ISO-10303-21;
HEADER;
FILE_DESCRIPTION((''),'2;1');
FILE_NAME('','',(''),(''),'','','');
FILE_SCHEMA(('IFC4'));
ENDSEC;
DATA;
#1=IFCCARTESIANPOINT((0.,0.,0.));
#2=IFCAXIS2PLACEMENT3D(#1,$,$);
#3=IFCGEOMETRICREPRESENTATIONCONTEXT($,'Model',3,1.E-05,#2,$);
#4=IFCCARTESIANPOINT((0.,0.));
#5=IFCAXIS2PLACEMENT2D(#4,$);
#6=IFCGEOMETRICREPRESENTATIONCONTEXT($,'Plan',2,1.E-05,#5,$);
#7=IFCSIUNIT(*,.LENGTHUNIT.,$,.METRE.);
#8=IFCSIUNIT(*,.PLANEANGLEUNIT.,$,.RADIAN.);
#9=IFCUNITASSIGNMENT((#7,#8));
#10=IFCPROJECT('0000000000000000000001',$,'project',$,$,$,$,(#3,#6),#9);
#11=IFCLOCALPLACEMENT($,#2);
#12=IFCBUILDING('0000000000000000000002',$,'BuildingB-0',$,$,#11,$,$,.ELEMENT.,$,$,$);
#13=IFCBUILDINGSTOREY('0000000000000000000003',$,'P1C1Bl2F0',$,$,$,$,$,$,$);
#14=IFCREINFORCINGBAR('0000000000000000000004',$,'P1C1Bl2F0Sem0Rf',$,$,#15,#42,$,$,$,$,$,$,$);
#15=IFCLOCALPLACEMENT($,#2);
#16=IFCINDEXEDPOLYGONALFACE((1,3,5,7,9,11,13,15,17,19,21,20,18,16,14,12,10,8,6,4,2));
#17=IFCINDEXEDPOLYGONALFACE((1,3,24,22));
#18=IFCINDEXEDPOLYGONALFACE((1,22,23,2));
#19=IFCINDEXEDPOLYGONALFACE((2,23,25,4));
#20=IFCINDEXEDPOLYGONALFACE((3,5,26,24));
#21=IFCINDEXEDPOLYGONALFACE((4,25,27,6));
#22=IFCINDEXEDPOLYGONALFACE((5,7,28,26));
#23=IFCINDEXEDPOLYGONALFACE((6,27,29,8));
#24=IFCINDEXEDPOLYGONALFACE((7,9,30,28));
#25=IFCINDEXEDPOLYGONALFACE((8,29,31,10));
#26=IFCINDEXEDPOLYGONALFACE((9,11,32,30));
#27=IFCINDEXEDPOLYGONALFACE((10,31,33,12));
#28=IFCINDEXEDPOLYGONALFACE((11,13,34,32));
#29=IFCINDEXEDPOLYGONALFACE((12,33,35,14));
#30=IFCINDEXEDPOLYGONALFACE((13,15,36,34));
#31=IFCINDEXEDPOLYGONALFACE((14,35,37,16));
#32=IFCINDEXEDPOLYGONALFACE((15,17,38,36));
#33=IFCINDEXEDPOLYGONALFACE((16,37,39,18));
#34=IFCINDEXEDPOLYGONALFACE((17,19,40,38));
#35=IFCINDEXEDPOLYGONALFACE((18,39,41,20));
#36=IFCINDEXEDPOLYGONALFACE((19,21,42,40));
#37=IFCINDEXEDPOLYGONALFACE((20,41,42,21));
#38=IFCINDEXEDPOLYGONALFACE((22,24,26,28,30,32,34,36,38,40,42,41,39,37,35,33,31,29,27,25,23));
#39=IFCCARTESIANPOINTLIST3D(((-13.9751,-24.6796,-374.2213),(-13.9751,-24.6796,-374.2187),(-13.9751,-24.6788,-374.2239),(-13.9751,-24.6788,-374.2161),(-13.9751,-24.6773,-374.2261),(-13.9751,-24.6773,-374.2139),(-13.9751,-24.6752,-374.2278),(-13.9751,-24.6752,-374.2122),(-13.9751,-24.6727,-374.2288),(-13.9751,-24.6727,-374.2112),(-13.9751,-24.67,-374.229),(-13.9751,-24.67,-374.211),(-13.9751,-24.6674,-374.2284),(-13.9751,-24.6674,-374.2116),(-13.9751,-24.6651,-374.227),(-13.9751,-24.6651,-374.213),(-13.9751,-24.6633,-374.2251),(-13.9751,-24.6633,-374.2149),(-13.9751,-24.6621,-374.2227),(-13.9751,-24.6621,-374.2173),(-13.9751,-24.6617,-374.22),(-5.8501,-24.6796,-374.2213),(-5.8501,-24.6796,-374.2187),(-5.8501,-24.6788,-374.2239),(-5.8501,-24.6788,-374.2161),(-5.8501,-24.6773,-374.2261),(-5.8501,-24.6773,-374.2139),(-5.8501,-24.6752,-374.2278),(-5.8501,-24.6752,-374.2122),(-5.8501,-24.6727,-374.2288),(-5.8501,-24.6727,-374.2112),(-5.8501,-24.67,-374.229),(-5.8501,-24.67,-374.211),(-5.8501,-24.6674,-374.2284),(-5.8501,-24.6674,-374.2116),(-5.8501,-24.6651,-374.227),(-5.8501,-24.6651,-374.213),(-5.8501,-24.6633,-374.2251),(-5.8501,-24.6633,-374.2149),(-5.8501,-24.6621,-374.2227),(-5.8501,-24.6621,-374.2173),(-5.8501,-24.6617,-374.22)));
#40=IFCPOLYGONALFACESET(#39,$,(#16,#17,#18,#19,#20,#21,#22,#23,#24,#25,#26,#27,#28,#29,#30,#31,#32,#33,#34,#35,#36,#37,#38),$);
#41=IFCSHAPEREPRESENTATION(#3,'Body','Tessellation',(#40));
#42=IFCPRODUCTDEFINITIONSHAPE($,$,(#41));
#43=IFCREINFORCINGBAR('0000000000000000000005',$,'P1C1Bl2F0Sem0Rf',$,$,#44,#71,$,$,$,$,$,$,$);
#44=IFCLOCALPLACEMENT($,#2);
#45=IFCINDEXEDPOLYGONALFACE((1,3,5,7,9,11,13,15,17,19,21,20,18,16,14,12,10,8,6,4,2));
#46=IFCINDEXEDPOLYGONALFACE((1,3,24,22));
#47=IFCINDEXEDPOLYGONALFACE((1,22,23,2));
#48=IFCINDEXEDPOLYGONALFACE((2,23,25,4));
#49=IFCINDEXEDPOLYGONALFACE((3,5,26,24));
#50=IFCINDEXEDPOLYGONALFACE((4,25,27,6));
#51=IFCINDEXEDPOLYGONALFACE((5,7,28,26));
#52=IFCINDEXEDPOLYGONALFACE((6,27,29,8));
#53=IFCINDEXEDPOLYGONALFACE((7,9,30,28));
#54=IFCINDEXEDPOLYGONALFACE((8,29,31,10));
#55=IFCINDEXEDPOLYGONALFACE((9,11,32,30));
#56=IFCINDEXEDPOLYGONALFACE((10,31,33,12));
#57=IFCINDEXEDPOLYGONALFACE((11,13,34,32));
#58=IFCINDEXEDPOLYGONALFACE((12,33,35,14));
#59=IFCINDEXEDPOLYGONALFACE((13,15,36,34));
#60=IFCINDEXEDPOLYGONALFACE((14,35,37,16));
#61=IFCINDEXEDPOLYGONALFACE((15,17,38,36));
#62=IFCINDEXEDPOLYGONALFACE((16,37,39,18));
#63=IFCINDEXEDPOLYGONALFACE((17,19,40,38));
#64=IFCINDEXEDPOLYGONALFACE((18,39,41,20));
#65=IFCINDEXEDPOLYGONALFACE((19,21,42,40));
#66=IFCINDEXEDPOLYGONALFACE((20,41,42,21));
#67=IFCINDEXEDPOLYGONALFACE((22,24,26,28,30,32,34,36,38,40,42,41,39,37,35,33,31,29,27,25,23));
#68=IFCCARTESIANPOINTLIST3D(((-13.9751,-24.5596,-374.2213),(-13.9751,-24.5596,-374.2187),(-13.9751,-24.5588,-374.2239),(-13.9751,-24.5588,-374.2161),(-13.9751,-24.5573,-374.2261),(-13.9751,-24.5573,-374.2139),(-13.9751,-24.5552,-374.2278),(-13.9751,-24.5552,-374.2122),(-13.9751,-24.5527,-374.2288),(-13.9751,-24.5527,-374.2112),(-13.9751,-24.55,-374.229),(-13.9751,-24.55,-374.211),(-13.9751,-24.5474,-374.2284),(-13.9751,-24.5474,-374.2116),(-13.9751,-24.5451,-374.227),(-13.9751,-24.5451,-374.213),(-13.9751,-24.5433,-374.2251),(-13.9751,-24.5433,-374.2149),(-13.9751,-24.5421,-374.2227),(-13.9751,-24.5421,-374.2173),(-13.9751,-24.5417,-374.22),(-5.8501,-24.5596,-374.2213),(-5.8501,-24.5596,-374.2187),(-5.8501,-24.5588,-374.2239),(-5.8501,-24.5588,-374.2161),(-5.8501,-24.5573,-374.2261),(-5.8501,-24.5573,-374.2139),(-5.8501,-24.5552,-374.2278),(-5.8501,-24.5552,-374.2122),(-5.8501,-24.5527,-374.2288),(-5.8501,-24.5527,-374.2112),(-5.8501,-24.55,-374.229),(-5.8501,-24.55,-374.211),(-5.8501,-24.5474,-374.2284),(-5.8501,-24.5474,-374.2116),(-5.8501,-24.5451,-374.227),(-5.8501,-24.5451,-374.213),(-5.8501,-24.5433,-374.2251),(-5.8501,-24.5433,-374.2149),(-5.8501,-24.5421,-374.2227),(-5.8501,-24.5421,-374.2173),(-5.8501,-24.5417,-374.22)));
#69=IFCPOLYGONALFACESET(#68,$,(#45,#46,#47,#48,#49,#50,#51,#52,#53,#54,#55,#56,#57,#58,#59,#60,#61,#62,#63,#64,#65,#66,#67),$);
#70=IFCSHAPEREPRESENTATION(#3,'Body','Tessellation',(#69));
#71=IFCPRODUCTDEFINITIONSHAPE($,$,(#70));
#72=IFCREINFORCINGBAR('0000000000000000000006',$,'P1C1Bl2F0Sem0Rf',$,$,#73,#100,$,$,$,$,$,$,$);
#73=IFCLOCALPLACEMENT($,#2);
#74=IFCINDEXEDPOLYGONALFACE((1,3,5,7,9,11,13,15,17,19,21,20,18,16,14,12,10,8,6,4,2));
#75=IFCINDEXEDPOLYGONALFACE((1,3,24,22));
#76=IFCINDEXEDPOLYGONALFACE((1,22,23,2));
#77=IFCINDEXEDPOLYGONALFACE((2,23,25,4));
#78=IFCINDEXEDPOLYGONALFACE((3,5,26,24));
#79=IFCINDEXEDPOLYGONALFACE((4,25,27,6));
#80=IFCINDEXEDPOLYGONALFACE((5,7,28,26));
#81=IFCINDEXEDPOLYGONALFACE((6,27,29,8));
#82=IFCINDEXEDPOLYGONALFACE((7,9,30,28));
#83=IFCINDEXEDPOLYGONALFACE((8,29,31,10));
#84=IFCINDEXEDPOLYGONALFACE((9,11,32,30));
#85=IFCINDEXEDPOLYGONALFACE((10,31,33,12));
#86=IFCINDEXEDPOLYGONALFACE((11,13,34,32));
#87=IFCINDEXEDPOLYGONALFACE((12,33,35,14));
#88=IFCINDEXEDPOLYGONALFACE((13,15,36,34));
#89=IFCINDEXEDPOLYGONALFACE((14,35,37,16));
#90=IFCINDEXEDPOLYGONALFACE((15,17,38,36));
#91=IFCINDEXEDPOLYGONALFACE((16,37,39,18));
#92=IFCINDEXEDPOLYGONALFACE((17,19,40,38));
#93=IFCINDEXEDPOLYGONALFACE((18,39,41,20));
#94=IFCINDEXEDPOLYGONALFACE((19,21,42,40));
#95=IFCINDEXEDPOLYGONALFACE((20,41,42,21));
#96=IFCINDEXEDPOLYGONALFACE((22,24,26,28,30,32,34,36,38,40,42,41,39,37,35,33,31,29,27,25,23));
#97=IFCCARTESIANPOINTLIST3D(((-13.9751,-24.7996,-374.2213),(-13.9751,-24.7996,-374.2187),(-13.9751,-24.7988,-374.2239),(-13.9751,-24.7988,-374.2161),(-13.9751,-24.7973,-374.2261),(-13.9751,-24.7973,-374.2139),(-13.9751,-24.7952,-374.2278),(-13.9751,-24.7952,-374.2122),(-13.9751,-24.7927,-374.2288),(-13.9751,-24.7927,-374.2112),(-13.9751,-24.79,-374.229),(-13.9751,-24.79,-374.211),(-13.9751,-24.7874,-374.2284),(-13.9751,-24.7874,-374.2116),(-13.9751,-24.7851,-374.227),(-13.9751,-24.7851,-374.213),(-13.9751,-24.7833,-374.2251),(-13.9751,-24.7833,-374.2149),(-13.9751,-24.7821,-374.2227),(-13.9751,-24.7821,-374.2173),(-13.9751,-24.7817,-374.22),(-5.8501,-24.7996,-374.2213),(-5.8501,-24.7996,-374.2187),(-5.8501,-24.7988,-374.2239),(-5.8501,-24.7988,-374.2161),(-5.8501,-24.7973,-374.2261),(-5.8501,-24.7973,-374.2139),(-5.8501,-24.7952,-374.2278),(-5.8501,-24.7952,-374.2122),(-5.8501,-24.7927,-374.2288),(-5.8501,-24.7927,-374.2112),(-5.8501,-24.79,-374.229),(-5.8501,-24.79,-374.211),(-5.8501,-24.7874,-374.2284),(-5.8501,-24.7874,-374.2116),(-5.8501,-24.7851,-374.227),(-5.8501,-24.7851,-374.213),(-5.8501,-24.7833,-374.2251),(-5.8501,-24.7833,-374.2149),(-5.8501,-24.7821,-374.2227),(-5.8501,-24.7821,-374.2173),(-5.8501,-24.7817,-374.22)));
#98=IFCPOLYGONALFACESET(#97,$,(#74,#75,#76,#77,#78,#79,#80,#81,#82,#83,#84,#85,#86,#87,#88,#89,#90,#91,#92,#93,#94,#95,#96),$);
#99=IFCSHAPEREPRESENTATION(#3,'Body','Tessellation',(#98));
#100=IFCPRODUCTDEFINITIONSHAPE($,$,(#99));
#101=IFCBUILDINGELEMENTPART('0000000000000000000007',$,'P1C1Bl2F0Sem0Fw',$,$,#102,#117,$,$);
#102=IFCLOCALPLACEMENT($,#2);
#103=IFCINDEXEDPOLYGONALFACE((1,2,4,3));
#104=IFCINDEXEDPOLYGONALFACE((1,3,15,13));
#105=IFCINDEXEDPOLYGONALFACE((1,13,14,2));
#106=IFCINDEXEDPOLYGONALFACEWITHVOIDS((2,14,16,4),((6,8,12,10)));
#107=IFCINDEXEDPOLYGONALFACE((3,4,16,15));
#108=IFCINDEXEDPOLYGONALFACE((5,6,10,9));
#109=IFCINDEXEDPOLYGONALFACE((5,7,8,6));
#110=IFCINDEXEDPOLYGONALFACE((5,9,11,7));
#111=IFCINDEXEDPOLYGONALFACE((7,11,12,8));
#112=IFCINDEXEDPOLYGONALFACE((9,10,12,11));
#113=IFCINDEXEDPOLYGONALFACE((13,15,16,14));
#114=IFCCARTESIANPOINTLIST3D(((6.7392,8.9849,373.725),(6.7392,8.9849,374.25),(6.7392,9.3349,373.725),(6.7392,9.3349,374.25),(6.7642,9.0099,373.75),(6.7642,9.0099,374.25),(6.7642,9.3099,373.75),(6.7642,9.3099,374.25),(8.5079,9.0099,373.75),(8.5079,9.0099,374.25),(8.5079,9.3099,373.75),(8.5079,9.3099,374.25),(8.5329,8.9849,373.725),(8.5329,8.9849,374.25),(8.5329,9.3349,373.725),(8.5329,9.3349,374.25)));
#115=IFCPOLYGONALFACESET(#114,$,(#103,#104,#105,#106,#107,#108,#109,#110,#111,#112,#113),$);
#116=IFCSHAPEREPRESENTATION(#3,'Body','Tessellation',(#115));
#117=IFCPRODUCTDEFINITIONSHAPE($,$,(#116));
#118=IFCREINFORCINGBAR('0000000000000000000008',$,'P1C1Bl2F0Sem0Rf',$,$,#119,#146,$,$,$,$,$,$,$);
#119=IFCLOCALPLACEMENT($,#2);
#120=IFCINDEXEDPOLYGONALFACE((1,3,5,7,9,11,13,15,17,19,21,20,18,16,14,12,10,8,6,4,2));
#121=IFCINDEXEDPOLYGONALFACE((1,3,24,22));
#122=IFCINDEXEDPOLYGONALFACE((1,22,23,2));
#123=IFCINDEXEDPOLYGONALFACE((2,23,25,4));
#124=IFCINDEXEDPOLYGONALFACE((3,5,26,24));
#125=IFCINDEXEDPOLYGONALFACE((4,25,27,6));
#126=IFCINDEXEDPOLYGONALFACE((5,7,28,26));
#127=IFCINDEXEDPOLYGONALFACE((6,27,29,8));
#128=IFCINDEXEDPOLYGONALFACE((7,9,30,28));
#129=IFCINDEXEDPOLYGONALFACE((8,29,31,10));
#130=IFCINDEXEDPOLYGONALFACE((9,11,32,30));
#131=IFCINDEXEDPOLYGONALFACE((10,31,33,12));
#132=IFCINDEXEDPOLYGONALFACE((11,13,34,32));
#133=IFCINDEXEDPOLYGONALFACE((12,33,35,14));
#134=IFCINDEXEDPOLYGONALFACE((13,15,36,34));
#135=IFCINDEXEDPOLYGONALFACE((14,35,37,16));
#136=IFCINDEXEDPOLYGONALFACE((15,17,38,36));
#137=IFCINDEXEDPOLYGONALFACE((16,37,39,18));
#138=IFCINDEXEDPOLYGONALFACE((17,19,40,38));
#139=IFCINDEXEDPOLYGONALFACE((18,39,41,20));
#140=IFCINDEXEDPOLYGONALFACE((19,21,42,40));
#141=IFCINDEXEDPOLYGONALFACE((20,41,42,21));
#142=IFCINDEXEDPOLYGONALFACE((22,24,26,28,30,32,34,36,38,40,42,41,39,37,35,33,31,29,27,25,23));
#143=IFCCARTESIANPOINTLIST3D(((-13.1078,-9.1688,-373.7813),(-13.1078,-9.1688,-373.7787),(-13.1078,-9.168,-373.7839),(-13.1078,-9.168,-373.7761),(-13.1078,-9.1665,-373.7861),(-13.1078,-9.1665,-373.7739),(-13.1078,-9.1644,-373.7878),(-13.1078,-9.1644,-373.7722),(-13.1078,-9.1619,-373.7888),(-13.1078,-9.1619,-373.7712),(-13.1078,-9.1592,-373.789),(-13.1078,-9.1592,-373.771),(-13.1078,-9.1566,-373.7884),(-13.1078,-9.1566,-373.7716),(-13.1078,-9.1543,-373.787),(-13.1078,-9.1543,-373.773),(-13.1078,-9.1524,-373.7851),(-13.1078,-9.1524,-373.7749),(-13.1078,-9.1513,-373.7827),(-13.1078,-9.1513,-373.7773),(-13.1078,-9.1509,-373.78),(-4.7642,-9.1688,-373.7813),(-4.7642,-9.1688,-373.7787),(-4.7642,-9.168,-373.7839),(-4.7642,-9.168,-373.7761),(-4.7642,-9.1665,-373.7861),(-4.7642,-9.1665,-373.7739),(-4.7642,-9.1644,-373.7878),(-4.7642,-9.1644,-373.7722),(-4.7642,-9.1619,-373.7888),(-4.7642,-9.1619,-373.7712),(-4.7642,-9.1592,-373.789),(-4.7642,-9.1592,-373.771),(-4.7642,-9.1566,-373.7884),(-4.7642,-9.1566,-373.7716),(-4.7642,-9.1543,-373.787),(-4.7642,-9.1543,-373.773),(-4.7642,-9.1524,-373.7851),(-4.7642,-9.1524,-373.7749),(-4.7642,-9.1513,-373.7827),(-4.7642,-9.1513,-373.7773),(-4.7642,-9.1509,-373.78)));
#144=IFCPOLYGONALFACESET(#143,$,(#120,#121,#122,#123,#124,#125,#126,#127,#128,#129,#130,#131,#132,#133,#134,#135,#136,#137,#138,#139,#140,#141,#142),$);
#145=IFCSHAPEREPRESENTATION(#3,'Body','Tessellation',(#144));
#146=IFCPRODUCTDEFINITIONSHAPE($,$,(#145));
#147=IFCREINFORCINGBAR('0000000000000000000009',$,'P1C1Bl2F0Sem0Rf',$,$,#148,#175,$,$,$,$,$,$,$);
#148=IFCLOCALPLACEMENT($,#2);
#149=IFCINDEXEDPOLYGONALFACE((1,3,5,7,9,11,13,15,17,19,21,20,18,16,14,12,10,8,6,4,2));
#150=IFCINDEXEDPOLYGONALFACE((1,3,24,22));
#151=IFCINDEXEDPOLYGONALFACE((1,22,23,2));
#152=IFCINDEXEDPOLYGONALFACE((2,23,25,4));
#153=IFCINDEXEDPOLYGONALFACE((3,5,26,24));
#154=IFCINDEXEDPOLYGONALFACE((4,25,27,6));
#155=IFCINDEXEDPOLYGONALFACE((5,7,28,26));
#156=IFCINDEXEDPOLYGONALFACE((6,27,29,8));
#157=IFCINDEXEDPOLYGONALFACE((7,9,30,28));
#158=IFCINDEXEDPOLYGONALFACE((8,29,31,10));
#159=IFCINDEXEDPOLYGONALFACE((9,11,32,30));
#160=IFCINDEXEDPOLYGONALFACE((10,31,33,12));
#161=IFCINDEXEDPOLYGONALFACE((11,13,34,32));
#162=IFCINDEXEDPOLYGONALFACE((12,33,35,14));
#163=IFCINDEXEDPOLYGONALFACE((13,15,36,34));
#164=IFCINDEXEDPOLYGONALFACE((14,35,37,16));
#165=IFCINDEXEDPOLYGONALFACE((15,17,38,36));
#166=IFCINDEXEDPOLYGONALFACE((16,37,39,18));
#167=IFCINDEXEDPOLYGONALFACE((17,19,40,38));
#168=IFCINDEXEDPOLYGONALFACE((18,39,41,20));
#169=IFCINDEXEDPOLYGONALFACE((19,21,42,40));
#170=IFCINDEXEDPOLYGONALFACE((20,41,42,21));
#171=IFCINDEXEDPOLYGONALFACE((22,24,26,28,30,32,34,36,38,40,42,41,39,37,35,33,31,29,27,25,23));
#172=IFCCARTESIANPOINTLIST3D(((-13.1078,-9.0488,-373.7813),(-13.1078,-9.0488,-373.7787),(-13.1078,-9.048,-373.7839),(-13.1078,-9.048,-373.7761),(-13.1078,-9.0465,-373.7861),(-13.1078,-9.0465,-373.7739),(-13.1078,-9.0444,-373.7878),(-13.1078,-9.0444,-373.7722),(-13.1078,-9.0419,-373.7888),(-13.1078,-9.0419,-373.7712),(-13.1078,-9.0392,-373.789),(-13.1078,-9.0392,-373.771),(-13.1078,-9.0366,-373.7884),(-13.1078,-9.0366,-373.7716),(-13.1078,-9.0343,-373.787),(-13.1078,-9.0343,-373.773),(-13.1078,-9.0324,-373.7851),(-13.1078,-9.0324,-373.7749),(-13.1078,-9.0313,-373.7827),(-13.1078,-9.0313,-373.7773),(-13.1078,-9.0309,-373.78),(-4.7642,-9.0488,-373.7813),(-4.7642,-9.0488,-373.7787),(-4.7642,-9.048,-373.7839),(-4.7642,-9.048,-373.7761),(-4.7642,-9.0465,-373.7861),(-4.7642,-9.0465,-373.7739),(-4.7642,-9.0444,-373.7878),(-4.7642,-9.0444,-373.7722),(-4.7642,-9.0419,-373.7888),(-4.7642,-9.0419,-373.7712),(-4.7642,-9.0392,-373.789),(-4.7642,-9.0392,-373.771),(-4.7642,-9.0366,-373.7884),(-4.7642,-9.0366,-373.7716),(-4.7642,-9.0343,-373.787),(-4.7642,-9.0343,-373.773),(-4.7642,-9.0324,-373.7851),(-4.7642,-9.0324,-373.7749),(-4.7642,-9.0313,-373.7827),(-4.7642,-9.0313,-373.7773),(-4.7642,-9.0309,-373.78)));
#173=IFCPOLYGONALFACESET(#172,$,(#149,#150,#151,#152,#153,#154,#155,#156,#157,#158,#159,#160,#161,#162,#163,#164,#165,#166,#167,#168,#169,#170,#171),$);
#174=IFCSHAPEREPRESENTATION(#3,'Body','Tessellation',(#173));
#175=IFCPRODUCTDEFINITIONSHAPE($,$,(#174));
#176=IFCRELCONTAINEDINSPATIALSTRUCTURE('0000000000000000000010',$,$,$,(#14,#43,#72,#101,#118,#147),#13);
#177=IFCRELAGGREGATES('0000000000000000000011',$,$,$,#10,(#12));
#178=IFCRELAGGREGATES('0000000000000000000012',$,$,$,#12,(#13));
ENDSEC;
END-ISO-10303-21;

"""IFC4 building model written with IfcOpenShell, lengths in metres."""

from ifc_helpers import new_model, entity, si_unit, origin, origin_2d, place, context, project, spatial, polyline, outline, extrude, element, save


model = new_model("IFC4")

# Units and contexts
model_context = context("Model", 3, precision=1e-05, world=origin())
plan_context = context("Plan", 2, precision=1e-05, world=origin_2d())
ifc_project = project(units=[si_unit("LENGTHUNIT", "METRE"), si_unit("PLANEANGLEUNIT", "RADIAN")], contexts=[model_context, plan_context])

# Building, storey
building_placement = place(None, origin())
building = spatial("IfcBuilding", under=ifc_project, at=building_placement, Name="BuildingB-0", CompositionType="ELEMENT")
storey = spatial("IfcBuildingStorey", under=building, Name="P1C1Bl2F0")

# Reinforcing bars
element("IfcReinforcingBar", 1, inside=storey, Name="P1C1Bl2F0Sem0Rf", context=model_context, shape_type="SweptSolid", body=[
    entity("IfcSurfaceCurveSweptAreaSolid", entity("IfcCircleProfileDef", "AREA", None, None, 0.009), None, entity("IfcPolyline", [entity("IfcCartesianPoint", [5.8501, 24.6707, 374.22]), entity("IfcCartesianPoint", [13.9751, 24.6707, 374.22])]), None, None, entity("IfcPlane", entity("IfcAxis2Placement3D", entity("IfcCartesianPoint", [5.8501, 24.6707, 374.22]), entity("IfcDirection", [0.0, 0.0, 1.0]), entity("IfcDirection", [1.0, 0.0, 0.0])))),
])
element("IfcReinforcingBar", 2, inside=storey, Name="P1C1Bl2F0Sem0Rf", context=model_context, shape_type="SweptSolid", body=[
    entity("IfcSurfaceCurveSweptAreaSolid", entity("IfcCircleProfileDef", "AREA", None, None, 0.009), None, entity("IfcPolyline", [entity("IfcCartesianPoint", [5.8501, 24.5507, 374.22]), entity("IfcCartesianPoint", [13.9751, 24.5507, 374.22])]), None, None, entity("IfcPlane", entity("IfcAxis2Placement3D", entity("IfcCartesianPoint", [5.8501, 24.5507, 374.22]), entity("IfcDirection", [0.0, 0.0, 1.0]), entity("IfcDirection", [1.0, 0.0, 0.0])))),
])
element("IfcReinforcingBar", 3, inside=storey, Name="P1C1Bl2F0Sem0Rf", context=model_context, shape_type="SweptSolid", body=[
    entity("IfcSurfaceCurveSweptAreaSolid", entity("IfcCircleProfileDef", "AREA", None, None, 0.009), None, entity("IfcPolyline", [entity("IfcCartesianPoint", [5.8501, 24.7907, 374.22]), entity("IfcCartesianPoint", [13.9751, 24.7907, 374.22])]), None, None, entity("IfcPlane", entity("IfcAxis2Placement3D", entity("IfcCartesianPoint", [5.8501, 24.7907, 374.22]), entity("IfcDirection", [0.0, 0.0, 1.0]), entity("IfcDirection", [1.0, 0.0, 0.0])))),
])

# Building element part, opening
building_element_part_1 = element("IfcBuildingElementPart", 4, inside=storey, Name="P1C1Bl2F0Sem0Fw", context=model_context, shape_type="SweptSolid", body=[
    extrude(outline(polyline([(6.7392, 8.9849, 373.725), (6.7392, 9.3349, 373.725), (8.5329, 9.3349, 373.725), (8.5329, 8.9849, 373.725), (6.7392, 8.9849, 373.725)])), None, (0.0, 0.0, 1.0), 0.525),
])
element("IfcOpeningElement", 5, inside=storey, cuts=building_element_part_1, context=model_context, shape_type="SweptSolid", body=[
    extrude(outline(polyline([(6.7642, 9.0099, 373.75), (6.7642, 9.3099, 373.75), (8.5079, 9.3099, 373.75), (8.5079, 9.0099, 373.75), (6.7642, 9.0099, 373.75)])), None, (0.0, 0.0, 1.0), 0.5),
])

# Reinforcing bars
element("IfcReinforcingBar", 6, inside=storey, Name="P1C1Bl2F0Sem0Rf", context=model_context, shape_type="SweptSolid", body=[
    entity("IfcSurfaceCurveSweptAreaSolid", entity("IfcCircleProfileDef", "AREA", None, None, 0.009), None, entity("IfcPolyline", [entity("IfcCartesianPoint", [4.7642, 9.1599, 373.78]), entity("IfcCartesianPoint", [13.1078, 9.1599, 373.78])]), None, None, entity("IfcPlane", entity("IfcAxis2Placement3D", entity("IfcCartesianPoint", [4.7642, 9.1599, 373.78]), entity("IfcDirection", [0.0, 0.0, 1.0]), entity("IfcDirection", [1.0, 0.0, 0.0])))),
])
element("IfcReinforcingBar", 7, inside=storey, Name="P1C1Bl2F0Sem0Rf", context=model_context, shape_type="SweptSolid", body=[
    entity("IfcSurfaceCurveSweptAreaSolid", entity("IfcCircleProfileDef", "AREA", None, None, 0.009), None, entity("IfcPolyline", [entity("IfcCartesianPoint", [4.7642, 9.0399, 373.78]), entity("IfcCartesianPoint", [13.1078, 9.0399, 373.78])]), None, None, entity("IfcPlane", entity("IfcAxis2Placement3D", entity("IfcCartesianPoint", [4.7642, 9.0399, 373.78]), entity("IfcDirection", [0.0, 0.0, 1.0]), entity("IfcDirection", [1.0, 0.0, 0.0])))),
])

save(model, "model.ifc")
